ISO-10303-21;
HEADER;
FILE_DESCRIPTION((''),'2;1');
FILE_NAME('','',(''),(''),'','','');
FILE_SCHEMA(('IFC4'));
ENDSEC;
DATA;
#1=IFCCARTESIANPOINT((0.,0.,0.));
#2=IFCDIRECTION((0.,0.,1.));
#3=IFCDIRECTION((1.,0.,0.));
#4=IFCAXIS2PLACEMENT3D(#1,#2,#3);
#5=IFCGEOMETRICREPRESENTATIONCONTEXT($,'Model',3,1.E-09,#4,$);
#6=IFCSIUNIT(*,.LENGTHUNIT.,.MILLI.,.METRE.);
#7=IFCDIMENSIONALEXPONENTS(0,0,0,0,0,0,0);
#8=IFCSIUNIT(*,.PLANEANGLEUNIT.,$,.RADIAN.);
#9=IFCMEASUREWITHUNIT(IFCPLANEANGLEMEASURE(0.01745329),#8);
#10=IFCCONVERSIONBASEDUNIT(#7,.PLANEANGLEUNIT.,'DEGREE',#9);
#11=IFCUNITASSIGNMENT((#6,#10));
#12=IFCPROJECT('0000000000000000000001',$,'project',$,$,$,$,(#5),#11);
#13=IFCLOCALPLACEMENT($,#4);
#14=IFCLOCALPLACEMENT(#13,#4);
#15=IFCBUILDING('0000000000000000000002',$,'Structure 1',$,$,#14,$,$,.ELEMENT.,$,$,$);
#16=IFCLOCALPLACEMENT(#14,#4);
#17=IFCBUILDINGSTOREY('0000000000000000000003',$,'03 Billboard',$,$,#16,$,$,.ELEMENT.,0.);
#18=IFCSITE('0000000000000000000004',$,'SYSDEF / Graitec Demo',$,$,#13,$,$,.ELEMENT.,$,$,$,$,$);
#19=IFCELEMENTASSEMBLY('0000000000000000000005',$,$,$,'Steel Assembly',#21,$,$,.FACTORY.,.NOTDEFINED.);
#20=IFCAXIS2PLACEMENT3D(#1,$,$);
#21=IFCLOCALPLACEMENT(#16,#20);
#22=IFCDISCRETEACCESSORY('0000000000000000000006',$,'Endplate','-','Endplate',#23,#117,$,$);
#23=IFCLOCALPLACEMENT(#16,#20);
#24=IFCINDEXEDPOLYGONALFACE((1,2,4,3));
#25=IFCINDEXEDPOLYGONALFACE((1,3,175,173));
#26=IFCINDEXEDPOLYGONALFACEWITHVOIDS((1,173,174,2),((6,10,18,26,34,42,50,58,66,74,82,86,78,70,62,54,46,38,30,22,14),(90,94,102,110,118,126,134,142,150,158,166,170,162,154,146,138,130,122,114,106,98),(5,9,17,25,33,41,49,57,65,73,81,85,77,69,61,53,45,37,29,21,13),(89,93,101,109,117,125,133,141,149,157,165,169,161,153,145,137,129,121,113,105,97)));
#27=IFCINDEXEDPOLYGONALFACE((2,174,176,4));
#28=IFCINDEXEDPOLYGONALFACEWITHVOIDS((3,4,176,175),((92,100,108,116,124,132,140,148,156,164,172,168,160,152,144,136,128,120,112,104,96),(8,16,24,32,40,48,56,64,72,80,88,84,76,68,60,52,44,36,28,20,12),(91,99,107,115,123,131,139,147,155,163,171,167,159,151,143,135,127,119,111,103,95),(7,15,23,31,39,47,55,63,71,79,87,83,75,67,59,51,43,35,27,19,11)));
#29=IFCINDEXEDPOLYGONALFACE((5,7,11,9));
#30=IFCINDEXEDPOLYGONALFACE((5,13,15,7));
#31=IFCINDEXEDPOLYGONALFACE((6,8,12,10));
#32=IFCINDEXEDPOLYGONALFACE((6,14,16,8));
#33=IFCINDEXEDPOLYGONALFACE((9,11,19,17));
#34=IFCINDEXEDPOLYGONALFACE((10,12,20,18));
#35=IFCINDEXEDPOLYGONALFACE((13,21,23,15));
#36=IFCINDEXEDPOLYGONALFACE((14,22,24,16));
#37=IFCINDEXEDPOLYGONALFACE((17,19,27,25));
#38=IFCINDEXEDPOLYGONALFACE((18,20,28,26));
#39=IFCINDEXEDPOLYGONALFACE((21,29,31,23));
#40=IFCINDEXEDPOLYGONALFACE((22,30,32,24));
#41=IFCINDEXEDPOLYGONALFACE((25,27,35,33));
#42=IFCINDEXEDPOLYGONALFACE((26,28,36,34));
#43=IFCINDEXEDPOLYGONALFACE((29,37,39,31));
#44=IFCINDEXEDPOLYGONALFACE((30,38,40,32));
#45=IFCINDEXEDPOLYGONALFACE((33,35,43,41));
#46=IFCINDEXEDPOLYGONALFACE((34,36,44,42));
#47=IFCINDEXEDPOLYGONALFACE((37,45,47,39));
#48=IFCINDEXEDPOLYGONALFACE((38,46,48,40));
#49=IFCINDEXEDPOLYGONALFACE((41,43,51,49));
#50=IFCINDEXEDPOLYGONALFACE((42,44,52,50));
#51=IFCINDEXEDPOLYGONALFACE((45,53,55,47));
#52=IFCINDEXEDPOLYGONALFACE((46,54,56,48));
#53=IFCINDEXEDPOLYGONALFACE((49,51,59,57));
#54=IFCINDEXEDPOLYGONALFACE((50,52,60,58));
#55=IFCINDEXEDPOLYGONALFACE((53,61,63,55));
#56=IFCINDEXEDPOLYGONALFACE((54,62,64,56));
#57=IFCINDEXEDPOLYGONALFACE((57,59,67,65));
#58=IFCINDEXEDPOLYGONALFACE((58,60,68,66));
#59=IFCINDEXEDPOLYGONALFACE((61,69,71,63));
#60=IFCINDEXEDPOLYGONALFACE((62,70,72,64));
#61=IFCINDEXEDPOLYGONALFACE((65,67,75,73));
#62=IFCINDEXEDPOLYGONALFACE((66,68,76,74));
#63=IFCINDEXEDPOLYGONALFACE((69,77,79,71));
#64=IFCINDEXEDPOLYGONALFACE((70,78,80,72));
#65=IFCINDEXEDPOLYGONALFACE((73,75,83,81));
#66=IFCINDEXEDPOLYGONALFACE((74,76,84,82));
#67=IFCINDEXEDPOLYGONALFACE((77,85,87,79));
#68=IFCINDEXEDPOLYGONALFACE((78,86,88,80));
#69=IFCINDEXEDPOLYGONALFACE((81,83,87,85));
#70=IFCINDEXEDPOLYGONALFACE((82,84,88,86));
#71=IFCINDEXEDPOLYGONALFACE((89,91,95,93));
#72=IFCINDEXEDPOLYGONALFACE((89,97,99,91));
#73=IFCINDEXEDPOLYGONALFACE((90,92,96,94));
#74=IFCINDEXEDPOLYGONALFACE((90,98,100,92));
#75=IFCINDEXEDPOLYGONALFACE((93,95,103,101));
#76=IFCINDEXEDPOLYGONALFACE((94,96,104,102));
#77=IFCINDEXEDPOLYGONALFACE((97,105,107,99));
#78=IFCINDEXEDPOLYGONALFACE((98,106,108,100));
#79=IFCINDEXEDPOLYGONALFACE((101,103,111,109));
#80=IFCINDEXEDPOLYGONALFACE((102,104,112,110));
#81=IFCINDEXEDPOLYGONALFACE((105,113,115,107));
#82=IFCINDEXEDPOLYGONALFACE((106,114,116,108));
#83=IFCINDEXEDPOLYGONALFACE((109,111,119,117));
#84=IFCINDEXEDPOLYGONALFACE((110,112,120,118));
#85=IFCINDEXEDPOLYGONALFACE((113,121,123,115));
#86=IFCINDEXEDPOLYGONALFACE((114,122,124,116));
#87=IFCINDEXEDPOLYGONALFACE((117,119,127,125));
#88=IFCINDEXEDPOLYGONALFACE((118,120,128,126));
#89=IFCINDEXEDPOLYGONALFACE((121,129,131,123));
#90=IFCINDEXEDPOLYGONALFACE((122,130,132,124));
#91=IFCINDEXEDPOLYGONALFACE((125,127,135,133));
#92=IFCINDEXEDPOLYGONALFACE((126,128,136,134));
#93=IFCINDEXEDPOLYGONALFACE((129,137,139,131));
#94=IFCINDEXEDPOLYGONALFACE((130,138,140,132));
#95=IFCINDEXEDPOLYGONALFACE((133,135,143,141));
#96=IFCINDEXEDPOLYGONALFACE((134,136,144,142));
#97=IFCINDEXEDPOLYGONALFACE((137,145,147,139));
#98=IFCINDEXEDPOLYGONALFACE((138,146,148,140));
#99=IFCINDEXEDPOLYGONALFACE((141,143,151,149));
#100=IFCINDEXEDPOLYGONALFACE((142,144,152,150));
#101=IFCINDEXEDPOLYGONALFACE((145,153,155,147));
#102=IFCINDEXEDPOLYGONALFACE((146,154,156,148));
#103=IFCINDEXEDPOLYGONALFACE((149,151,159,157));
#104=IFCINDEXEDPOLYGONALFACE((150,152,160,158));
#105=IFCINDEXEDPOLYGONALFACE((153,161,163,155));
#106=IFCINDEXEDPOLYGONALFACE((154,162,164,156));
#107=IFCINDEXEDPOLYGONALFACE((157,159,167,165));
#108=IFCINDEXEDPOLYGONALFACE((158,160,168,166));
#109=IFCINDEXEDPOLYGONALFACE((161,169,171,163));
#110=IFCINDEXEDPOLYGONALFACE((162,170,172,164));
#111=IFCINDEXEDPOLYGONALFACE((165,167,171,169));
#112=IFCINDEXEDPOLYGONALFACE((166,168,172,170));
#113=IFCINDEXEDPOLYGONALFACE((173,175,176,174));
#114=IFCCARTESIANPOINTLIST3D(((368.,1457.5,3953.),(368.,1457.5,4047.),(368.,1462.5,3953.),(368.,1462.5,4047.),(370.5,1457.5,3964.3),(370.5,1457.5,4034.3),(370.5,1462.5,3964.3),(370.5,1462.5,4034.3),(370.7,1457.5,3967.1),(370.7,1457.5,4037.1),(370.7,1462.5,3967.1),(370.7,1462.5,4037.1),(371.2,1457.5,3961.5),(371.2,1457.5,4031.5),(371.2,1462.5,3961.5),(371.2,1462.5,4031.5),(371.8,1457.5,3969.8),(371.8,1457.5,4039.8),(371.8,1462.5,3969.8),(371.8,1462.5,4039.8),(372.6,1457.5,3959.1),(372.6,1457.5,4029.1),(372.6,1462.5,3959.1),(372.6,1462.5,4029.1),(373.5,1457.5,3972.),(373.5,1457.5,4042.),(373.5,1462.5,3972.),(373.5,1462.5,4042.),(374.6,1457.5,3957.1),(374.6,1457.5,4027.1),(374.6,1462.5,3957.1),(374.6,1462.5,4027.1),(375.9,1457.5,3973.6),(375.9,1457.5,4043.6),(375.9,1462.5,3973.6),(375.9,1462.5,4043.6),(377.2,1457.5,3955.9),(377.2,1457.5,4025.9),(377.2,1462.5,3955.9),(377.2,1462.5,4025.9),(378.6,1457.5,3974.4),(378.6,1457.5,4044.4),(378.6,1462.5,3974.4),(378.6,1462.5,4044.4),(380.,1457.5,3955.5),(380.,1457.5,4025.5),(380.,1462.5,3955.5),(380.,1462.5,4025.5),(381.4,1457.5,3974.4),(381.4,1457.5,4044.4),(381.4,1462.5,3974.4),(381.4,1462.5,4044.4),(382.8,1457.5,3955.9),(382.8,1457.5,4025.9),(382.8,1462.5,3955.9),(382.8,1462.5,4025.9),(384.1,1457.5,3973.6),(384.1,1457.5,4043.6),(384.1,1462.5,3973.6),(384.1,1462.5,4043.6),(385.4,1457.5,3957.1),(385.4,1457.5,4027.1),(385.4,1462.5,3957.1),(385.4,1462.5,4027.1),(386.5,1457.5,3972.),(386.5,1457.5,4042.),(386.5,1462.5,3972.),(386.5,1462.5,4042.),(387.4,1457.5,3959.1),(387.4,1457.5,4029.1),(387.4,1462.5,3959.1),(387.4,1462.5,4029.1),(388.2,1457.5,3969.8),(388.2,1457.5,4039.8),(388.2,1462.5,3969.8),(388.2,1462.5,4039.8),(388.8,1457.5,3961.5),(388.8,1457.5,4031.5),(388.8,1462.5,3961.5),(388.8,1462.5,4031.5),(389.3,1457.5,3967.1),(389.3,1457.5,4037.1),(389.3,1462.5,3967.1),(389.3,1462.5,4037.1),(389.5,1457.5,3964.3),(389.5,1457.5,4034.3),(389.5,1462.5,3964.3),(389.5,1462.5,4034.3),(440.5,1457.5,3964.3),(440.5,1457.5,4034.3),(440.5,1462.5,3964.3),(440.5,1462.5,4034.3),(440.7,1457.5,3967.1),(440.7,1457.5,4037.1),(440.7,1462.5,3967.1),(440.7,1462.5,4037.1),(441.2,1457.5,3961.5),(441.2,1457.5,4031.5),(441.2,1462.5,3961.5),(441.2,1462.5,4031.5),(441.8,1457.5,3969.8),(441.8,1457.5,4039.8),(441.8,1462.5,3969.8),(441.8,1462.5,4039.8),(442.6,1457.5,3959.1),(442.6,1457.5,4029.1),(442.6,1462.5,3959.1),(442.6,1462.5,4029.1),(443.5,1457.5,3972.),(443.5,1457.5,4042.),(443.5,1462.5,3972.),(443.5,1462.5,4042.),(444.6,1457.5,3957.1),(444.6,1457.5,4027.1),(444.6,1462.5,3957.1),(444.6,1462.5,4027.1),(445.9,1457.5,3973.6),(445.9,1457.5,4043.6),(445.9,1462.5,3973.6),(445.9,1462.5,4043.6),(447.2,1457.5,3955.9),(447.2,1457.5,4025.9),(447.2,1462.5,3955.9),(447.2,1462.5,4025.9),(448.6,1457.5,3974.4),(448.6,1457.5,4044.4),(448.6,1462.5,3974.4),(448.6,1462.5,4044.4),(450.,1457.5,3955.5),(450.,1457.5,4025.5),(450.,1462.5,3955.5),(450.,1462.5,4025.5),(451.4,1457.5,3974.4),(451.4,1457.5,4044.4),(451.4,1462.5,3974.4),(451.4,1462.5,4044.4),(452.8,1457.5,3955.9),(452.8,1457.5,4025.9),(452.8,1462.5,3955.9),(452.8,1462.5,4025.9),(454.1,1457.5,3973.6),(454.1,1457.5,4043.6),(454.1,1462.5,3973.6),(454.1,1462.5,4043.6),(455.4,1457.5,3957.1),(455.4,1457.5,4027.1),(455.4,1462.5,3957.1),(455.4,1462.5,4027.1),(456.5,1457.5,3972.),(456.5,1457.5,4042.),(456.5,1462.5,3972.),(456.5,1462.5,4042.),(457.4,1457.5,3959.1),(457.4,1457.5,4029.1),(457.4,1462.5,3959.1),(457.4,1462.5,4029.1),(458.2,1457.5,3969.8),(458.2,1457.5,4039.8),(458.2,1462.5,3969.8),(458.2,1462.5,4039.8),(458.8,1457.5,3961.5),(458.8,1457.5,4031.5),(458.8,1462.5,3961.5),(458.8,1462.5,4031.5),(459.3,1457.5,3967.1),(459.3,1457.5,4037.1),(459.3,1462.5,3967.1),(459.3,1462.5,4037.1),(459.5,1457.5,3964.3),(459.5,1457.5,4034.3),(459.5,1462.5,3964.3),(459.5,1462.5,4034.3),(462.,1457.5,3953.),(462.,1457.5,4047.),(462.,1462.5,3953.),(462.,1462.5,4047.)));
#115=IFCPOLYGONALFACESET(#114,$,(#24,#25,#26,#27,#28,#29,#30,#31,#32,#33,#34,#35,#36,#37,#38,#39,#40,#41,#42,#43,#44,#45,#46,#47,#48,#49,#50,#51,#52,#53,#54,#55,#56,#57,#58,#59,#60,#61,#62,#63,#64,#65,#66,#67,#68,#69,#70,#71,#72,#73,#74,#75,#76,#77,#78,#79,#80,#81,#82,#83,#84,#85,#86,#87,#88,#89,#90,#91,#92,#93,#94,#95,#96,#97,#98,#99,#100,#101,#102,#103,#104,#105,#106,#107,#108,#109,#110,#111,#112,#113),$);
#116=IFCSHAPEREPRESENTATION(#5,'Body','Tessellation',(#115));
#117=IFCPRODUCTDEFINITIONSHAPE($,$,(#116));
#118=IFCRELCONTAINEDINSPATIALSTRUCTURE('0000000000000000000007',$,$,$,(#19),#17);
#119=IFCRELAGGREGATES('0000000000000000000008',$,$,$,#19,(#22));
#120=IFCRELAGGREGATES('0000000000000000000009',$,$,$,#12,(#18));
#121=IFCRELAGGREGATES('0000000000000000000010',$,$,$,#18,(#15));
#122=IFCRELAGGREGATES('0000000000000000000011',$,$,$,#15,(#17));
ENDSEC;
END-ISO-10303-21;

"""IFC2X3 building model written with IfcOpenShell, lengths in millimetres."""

from ifc_helpers import new_model, entity, si_unit, converted_unit, frame, frame_2d, origin, origin_with_axes, place, context, project, spatial, polyline, circle, outline, extrude, element, aggregate, save


model = new_model("IFC2X3")

# Units and contexts
model_context = context("Model", 3, precision=1e-09, world=origin_with_axes())
ifc_project = project(units=[si_unit("LENGTHUNIT", "METRE", prefix="MILLI"), converted_unit("PLANEANGLEUNIT", "DEGREE", entity("IfcPlaneAngleMeasure", 0.01745329), si_unit("PLANEANGLEUNIT", "RADIAN"), dimensions=[0, 0, 0, 0, 0, 0, 0])], contexts=[model_context])

# Site, building, storey
site_placement = place(None, origin_with_axes())
site = spatial("IfcSite", under=ifc_project, at=site_placement, Name="SYSDEF / Graitec Demo", CompositionType="ELEMENT")
building_placement = place(site_placement, origin_with_axes())
building = spatial("IfcBuilding", under=site, at=building_placement, Name="Structure 1", CompositionType="ELEMENT")
storey_placement = place(building_placement, origin_with_axes())
storey = spatial("IfcBuildingStorey", under=building, at=storey_placement, Name="03 Billboard", CompositionType="ELEMENT", Elevation=0.0)

# Element assembly, discrete accessory, openings
assembly_1_placement = place(None, frame((-415.0, 391.8, 4000.0), z_axis=(0.0, -1.0, 0.0), x_axis=(1.0, 0.0, 0.0)))
assembly_1 = element("IfcElementAssembly", 1, at=assembly_1_placement, inside=storey, ObjectType="Steel Assembly", AssemblyPlace="FACTORY", PredefinedType="NOTDEFINED")
discrete_accessory_1_placement = place(assembly_1_placement, frame((783.0, 47.0, -1065.7), z_axis=(0.0, 0.0, -1.0), x_axis=(1.0, 0.0, 0.0)))
discrete_accessory_1 = element("IfcDiscreteAccessory", 2, at=discrete_accessory_1_placement, Name="Endplate", Description="-", ObjectType="Endplate", context=model_context, shape_type="SweptSolid", body=[
    extrude(outline(polyline([(0.0, 0.0), (94.0, 0.0), (94.0, 94.0), (0.0, 94.0), (0.0, 0.0)])), origin_with_axes(), (0.0, 0.0, 1.0), 5.0),
])
opening_1_placement = place(discrete_accessory_1_placement, frame((47.0, 47.0, 5.5), z_axis=(0.0, 0.0, -1.0), x_axis=(0.0, 1.0, 0.0)))
element("IfcOpeningElement", 3, at=opening_1_placement, cuts=discrete_accessory_1, ObjectType="Opening", context=model_context, shape_type="SweptSolid", body=[
    extrude(circle(Radius=9.5, at=frame_2d((35.0, 35.0), x_axis=(1.0, 0.0))), origin(), (0.0, 0.0, 1.0), 6.0),
])
opening_2_placement = place(discrete_accessory_1_placement, frame((47.0, 47.0, 5.5), z_axis=(0.0, 0.0, -1.0), x_axis=(0.0, 1.0, 0.0)))
element("IfcOpeningElement", 4, at=opening_2_placement, cuts=discrete_accessory_1, ObjectType="Opening", context=model_context, shape_type="SweptSolid", body=[
    extrude(circle(Radius=9.5, at=frame_2d((-35.0, 35.0), x_axis=(1.0, 0.0))), origin(), (0.0, 0.0, 1.0), 6.0),
])
opening_3_placement = place(discrete_accessory_1_placement, frame((47.0, 47.0, 5.5), z_axis=(0.0, 0.0, -1.0), x_axis=(0.0, 1.0, 0.0)))
element("IfcOpeningElement", 5, at=opening_3_placement, cuts=discrete_accessory_1, ObjectType="Opening", context=model_context, shape_type="SweptSolid", body=[
    extrude(circle(Radius=9.5, at=frame_2d((35.0, -35.0), x_axis=(1.0, 0.0))), origin(), (0.0, 0.0, 1.0), 6.0),
])
opening_4_placement = place(discrete_accessory_1_placement, frame((47.0, 47.0, 5.5), z_axis=(0.0, 0.0, -1.0), x_axis=(0.0, 1.0, 0.0)))
element("IfcOpeningElement", 6, at=opening_4_placement, cuts=discrete_accessory_1, ObjectType="Opening", context=model_context, shape_type="SweptSolid", body=[
    extrude(circle(Radius=9.5, at=frame_2d((-35.0, -35.0), x_axis=(1.0, 0.0))), origin(), (0.0, 0.0, 1.0), 6.0),
])
aggregate(assembly_1, [discrete_accessory_1])

save(model, "model.ifc")
